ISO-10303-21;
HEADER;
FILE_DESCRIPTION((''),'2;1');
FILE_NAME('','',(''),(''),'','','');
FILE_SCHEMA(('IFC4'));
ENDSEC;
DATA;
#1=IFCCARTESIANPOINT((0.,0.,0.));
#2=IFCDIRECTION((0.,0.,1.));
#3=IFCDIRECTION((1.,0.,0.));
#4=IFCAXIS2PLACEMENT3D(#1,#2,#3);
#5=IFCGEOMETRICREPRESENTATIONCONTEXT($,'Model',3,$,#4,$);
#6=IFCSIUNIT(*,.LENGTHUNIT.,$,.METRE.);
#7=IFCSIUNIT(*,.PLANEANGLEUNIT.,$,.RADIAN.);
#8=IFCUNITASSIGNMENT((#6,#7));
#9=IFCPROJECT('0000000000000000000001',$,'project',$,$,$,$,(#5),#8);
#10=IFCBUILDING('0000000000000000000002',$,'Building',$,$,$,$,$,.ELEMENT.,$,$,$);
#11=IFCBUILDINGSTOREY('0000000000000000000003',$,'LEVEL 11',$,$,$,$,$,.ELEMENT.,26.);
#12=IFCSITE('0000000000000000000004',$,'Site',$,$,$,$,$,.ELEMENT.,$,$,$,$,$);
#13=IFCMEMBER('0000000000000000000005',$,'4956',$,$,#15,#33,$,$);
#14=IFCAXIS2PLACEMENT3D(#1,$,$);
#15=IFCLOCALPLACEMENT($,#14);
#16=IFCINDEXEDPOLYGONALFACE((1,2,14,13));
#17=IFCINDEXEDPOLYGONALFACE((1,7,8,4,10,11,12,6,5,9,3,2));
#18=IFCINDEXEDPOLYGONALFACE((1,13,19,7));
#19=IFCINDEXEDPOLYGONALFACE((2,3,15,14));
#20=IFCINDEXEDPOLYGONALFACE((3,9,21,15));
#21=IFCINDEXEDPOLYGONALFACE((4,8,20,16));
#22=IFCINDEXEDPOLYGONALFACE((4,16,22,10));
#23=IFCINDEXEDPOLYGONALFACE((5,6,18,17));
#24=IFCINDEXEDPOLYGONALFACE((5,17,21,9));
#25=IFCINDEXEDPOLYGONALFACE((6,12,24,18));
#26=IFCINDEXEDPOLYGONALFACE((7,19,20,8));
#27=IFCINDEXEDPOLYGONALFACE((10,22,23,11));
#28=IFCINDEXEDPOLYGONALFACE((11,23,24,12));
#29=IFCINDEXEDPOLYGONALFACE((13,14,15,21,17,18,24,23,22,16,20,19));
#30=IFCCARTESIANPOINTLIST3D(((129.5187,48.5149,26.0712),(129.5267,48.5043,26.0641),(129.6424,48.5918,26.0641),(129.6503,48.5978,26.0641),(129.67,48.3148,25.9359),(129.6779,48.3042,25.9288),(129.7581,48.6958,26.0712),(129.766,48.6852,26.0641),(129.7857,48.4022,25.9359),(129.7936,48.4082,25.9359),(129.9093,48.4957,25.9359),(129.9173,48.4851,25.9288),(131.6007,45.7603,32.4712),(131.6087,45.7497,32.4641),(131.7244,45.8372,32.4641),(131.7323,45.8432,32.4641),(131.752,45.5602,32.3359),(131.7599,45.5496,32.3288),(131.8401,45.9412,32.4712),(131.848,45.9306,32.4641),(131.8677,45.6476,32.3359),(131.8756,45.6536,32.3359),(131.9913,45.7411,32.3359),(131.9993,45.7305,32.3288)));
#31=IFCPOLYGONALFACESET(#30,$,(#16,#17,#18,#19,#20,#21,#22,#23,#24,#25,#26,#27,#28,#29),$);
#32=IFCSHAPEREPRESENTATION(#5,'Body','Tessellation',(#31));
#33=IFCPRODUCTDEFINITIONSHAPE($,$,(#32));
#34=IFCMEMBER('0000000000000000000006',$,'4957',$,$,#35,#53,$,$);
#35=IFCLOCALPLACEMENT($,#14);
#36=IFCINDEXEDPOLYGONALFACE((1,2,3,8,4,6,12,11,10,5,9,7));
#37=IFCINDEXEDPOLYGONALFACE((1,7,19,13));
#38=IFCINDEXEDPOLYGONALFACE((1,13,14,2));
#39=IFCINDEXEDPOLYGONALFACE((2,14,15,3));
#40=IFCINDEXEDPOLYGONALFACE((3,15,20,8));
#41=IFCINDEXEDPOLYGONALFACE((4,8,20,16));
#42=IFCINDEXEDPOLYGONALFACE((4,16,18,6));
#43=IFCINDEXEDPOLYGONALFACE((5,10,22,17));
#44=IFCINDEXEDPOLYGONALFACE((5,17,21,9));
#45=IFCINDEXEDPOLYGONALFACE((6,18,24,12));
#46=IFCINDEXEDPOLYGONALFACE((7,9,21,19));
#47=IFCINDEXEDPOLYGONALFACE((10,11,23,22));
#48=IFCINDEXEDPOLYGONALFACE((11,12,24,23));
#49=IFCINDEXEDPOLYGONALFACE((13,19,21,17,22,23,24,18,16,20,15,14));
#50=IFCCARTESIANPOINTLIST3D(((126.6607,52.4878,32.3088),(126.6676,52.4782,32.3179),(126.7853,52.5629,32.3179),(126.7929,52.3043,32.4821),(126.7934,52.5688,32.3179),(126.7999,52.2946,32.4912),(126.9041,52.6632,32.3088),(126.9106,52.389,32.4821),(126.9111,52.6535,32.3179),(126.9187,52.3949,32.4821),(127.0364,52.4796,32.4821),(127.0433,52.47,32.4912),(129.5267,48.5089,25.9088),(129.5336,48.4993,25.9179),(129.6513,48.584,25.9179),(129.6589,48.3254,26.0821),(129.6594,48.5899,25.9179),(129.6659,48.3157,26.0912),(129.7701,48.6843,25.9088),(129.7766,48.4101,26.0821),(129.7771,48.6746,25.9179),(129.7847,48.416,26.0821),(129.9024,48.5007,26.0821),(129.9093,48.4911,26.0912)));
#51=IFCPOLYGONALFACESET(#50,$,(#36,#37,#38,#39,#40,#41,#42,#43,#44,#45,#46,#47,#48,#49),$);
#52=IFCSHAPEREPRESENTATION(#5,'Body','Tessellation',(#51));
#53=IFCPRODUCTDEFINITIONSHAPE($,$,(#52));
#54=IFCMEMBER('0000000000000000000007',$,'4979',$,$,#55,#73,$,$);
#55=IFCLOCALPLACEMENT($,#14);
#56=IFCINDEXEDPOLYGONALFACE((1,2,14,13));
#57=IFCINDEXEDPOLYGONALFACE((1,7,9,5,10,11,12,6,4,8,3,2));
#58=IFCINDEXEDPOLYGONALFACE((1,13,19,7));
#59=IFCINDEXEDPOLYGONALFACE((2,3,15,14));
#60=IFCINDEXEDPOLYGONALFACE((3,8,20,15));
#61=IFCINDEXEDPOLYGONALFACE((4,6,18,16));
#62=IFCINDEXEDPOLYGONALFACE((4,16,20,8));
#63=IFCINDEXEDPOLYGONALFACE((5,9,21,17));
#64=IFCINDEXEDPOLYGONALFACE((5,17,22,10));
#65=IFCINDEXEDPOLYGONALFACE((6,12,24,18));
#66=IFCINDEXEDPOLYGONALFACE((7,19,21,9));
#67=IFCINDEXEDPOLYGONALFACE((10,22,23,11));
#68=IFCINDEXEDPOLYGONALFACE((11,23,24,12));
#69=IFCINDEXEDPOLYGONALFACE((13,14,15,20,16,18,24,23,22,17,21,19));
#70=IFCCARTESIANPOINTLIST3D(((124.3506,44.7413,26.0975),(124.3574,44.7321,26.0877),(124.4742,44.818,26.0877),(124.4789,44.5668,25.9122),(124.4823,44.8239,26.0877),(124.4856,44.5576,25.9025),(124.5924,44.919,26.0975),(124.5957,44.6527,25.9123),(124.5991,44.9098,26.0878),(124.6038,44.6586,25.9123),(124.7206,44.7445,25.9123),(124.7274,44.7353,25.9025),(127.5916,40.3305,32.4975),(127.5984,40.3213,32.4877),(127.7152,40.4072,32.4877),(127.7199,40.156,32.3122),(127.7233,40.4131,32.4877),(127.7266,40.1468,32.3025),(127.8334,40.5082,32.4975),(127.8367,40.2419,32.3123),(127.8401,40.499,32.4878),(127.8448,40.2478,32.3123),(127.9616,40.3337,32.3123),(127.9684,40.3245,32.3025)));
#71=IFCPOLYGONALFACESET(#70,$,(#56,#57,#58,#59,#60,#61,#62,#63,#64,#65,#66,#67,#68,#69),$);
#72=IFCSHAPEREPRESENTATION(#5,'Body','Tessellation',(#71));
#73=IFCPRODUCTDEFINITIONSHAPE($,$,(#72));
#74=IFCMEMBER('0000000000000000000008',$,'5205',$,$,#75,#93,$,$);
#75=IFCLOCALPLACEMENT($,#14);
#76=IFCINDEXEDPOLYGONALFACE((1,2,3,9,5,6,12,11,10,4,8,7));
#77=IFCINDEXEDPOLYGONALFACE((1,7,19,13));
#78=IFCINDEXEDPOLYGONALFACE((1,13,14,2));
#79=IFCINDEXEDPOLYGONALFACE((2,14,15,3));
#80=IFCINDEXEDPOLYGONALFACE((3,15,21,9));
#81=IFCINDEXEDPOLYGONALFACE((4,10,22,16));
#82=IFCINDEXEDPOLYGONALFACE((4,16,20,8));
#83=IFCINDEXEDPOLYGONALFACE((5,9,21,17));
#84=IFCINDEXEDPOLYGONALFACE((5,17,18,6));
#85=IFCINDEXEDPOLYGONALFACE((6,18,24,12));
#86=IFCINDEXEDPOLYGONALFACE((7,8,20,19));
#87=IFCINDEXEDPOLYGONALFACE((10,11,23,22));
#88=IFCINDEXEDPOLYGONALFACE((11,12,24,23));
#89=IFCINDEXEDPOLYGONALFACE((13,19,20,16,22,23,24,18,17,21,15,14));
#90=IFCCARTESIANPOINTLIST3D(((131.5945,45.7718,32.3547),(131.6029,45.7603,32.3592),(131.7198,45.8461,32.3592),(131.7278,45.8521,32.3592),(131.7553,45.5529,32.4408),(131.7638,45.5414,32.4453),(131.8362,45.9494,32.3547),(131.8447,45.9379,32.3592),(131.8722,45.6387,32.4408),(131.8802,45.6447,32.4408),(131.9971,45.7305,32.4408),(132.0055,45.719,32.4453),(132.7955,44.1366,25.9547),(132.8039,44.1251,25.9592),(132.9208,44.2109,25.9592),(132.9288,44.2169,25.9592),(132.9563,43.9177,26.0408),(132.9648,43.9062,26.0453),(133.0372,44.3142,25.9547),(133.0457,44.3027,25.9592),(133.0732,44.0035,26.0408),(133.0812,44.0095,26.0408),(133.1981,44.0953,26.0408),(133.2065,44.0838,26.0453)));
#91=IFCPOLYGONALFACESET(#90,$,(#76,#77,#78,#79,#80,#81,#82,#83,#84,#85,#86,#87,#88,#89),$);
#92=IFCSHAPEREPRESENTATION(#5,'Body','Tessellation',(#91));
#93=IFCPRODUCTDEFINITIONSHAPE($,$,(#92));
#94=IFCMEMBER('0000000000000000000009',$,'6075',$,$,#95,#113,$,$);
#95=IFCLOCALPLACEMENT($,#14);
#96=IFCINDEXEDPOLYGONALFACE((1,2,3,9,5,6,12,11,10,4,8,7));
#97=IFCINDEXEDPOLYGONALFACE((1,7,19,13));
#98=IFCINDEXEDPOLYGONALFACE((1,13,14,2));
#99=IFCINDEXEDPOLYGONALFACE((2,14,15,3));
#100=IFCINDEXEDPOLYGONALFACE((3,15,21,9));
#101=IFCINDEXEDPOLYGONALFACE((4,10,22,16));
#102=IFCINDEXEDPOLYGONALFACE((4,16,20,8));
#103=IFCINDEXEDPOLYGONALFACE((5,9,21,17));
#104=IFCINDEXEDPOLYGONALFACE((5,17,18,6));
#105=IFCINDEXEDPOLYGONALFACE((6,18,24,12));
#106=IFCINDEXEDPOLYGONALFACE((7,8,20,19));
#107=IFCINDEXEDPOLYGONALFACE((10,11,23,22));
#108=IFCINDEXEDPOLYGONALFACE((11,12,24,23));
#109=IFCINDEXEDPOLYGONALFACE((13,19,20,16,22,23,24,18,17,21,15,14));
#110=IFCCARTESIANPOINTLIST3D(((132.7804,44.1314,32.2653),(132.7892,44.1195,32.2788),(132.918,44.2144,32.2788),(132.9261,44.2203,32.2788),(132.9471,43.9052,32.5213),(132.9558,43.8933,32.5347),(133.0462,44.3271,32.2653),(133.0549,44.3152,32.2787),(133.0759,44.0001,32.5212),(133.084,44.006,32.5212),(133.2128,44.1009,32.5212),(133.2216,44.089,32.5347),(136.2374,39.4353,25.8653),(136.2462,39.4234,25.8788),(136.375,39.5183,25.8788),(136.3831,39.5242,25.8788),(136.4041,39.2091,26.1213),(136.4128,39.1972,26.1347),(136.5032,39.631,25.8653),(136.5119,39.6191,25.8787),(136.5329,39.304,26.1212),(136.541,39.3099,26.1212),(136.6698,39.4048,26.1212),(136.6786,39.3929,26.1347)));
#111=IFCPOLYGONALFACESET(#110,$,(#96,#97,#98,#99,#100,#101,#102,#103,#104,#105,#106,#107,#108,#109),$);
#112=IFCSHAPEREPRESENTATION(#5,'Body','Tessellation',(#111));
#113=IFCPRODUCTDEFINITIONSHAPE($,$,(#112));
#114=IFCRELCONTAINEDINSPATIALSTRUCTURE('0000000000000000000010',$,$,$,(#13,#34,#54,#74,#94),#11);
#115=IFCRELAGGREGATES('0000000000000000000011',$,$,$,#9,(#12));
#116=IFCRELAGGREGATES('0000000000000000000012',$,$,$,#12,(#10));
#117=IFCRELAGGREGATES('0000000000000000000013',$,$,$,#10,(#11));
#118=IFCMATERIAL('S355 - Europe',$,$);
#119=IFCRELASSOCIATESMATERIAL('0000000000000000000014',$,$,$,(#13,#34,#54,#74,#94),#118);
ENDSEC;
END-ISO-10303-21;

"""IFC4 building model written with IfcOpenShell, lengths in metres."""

from ifc_helpers import new_model, si_unit, frame, origin_with_axes, origin_2d_with_axis, place, context, project, spatial, i_section, extrude, material, material_profile, profile_set, profile_usage, element, save


model = new_model("IFC4")

# Units and contexts
model_context = context("Model", 3, world=origin_with_axes())
ifc_project = project(units=[si_unit("LENGTHUNIT", "METRE"), si_unit("PLANEANGLEUNIT", "RADIAN")], contexts=[model_context])

# Site, building, storey
site = spatial("IfcSite", under=ifc_project, Name="Site", CompositionType="ELEMENT")
building = spatial("IfcBuilding", under=site, Name="Building", CompositionType="ELEMENT")
storey = spatial("IfcBuildingStorey", under=building, Name="LEVEL 11", CompositionType="ELEMENT", Elevation=26.0)

# Shared definitions
ifc_material = material(Name="S355 - Europe")

# Members
ifc_material_profile_1 = material_profile(ifc_material, i_section(OverallWidth=0.3, OverallDepth=0.3, WebThickness=0.01, FlangeThickness=0.015, at=origin_2d_with_axis()))
ifc_profile_set_1 = profile_set([ifc_material_profile_1])
ifc_profile_usage_1 = profile_usage(ifc_profile_set_1, cardinal=10)
member_1_placement = place(None, frame((131.8, 45.7454, 32.4), z_axis=(-0.286302, 0.378793, -0.880083), x_axis=(-0.797762, -0.602972, 0.0)))
element("IfcMember", 1, at=member_1_placement, inside=storey, material=ifc_profile_usage_1, Name="4956", context=model_context, shape_type="SweptSolid", body=[
    extrude(i_section(OverallWidth=0.3, OverallDepth=0.3, WebThickness=0.01, FlangeThickness=0.015, at=origin_2d_with_axis()), origin_with_axes(), (0.0, 0.0, 1.0), 7.272),
])
ifc_material_profile_2 = material_profile(ifc_material, i_section(OverallWidth=0.3, OverallDepth=0.3, WebThickness=0.01, FlangeThickness=0.015, at=origin_2d_with_axis()))
ifc_profile_set_2 = profile_set([ifc_material_profile_2])
ifc_profile_usage_2 = profile_usage(ifc_profile_set_2, cardinal=10)
member_2_placement = place(None, frame((129.718, 48.5, 26.0), z_axis=(-0.355468, 0.493501, 0.793788), x_axis=(-0.811322, -0.584599, 0.0)))
element("IfcMember", 2, at=member_2_placement, inside=storey, material=ifc_profile_usage_2, Name="4957", context=model_context, shape_type="SweptSolid", body=[
    extrude(i_section(OverallWidth=0.3, OverallDepth=0.3, WebThickness=0.01, FlangeThickness=0.015, at=origin_2d_with_axis()), origin_with_axes(), (0.0, 0.0, 1.0), 8.0626),
])
ifc_material_profile_3 = material_profile(ifc_material, i_section(OverallWidth=0.3, OverallDepth=0.3, WebThickness=0.01, FlangeThickness=0.015, at=origin_2d_with_axis()))
ifc_profile_set_3 = profile_set([ifc_material_profile_3])
ifc_profile_usage_3 = profile_usage(ifc_profile_set_3, cardinal=10)
member_3_placement = place(None, frame((127.78, 40.3275, 32.4), z_axis=(-0.384855, 0.523764, -0.759973), x_axis=(-0.805765, -0.592235, 0.0)))
element("IfcMember", 3, at=member_3_placement, inside=storey, material=ifc_profile_usage_3, Name="4979", context=model_context, shape_type="SweptSolid", body=[
    extrude(i_section(OverallWidth=0.3, OverallDepth=0.3, WebThickness=0.01, FlangeThickness=0.015, at=origin_2d_with_axis()), origin_with_axes(), (0.0, 0.0, 1.0), 8.4214),
])
ifc_material_profile_4 = material_profile(ifc_material, i_section(OverallWidth=0.3, OverallDepth=0.3, WebThickness=0.01, FlangeThickness=0.015, at=origin_2d_with_axis()))
ifc_profile_set_4 = profile_set([ifc_material_profile_4])
ifc_profile_usage_4 = profile_usage(ifc_profile_set_4, cardinal=10)
member_4_placement = place(None, frame((131.8, 45.7454, 32.4), z_axis=(0.178883, -0.243555, -0.953248), x_axis=(0.805798, 0.59219, 0.0)))
element("IfcMember", 4, at=member_4_placement, inside=storey, material=ifc_profile_usage_4, Name="5205", context=model_context, shape_type="SweptSolid", body=[
    extrude(i_section(OverallWidth=0.3, OverallDepth=0.3, WebThickness=0.01, FlangeThickness=0.015, at=origin_2d_with_axis()), origin_with_axes(), (0.0, 0.0, 1.0), 6.7139),
])
ifc_material_profile_5 = material_profile(ifc_material, i_section(OverallWidth=0.33, OverallDepth=0.4, WebThickness=0.01, FlangeThickness=0.02, at=origin_2d_with_axis()))
ifc_profile_set_5 = profile_set([ifc_material_profile_5])
ifc_profile_usage_5 = profile_usage(ifc_profile_set_5, cardinal=10)
member_5_placement = place(None, frame((136.458, 39.4141, 26.0), z_axis=(-0.399275, 0.542388, 0.739185), x_axis=(-0.805056, -0.593199, 0.0)))
element("IfcMember", 5, at=member_5_placement, inside=storey, material=ifc_profile_usage_5, Name="6075", context=model_context, shape_type="SweptSolid", body=[
    extrude(i_section(OverallWidth=0.33, OverallDepth=0.4, WebThickness=0.01, FlangeThickness=0.02, at=origin_2d_with_axis()), origin_with_axes(), (0.0, 0.0, 1.0), 8.6582),
])

save(model, "model.ifc")
